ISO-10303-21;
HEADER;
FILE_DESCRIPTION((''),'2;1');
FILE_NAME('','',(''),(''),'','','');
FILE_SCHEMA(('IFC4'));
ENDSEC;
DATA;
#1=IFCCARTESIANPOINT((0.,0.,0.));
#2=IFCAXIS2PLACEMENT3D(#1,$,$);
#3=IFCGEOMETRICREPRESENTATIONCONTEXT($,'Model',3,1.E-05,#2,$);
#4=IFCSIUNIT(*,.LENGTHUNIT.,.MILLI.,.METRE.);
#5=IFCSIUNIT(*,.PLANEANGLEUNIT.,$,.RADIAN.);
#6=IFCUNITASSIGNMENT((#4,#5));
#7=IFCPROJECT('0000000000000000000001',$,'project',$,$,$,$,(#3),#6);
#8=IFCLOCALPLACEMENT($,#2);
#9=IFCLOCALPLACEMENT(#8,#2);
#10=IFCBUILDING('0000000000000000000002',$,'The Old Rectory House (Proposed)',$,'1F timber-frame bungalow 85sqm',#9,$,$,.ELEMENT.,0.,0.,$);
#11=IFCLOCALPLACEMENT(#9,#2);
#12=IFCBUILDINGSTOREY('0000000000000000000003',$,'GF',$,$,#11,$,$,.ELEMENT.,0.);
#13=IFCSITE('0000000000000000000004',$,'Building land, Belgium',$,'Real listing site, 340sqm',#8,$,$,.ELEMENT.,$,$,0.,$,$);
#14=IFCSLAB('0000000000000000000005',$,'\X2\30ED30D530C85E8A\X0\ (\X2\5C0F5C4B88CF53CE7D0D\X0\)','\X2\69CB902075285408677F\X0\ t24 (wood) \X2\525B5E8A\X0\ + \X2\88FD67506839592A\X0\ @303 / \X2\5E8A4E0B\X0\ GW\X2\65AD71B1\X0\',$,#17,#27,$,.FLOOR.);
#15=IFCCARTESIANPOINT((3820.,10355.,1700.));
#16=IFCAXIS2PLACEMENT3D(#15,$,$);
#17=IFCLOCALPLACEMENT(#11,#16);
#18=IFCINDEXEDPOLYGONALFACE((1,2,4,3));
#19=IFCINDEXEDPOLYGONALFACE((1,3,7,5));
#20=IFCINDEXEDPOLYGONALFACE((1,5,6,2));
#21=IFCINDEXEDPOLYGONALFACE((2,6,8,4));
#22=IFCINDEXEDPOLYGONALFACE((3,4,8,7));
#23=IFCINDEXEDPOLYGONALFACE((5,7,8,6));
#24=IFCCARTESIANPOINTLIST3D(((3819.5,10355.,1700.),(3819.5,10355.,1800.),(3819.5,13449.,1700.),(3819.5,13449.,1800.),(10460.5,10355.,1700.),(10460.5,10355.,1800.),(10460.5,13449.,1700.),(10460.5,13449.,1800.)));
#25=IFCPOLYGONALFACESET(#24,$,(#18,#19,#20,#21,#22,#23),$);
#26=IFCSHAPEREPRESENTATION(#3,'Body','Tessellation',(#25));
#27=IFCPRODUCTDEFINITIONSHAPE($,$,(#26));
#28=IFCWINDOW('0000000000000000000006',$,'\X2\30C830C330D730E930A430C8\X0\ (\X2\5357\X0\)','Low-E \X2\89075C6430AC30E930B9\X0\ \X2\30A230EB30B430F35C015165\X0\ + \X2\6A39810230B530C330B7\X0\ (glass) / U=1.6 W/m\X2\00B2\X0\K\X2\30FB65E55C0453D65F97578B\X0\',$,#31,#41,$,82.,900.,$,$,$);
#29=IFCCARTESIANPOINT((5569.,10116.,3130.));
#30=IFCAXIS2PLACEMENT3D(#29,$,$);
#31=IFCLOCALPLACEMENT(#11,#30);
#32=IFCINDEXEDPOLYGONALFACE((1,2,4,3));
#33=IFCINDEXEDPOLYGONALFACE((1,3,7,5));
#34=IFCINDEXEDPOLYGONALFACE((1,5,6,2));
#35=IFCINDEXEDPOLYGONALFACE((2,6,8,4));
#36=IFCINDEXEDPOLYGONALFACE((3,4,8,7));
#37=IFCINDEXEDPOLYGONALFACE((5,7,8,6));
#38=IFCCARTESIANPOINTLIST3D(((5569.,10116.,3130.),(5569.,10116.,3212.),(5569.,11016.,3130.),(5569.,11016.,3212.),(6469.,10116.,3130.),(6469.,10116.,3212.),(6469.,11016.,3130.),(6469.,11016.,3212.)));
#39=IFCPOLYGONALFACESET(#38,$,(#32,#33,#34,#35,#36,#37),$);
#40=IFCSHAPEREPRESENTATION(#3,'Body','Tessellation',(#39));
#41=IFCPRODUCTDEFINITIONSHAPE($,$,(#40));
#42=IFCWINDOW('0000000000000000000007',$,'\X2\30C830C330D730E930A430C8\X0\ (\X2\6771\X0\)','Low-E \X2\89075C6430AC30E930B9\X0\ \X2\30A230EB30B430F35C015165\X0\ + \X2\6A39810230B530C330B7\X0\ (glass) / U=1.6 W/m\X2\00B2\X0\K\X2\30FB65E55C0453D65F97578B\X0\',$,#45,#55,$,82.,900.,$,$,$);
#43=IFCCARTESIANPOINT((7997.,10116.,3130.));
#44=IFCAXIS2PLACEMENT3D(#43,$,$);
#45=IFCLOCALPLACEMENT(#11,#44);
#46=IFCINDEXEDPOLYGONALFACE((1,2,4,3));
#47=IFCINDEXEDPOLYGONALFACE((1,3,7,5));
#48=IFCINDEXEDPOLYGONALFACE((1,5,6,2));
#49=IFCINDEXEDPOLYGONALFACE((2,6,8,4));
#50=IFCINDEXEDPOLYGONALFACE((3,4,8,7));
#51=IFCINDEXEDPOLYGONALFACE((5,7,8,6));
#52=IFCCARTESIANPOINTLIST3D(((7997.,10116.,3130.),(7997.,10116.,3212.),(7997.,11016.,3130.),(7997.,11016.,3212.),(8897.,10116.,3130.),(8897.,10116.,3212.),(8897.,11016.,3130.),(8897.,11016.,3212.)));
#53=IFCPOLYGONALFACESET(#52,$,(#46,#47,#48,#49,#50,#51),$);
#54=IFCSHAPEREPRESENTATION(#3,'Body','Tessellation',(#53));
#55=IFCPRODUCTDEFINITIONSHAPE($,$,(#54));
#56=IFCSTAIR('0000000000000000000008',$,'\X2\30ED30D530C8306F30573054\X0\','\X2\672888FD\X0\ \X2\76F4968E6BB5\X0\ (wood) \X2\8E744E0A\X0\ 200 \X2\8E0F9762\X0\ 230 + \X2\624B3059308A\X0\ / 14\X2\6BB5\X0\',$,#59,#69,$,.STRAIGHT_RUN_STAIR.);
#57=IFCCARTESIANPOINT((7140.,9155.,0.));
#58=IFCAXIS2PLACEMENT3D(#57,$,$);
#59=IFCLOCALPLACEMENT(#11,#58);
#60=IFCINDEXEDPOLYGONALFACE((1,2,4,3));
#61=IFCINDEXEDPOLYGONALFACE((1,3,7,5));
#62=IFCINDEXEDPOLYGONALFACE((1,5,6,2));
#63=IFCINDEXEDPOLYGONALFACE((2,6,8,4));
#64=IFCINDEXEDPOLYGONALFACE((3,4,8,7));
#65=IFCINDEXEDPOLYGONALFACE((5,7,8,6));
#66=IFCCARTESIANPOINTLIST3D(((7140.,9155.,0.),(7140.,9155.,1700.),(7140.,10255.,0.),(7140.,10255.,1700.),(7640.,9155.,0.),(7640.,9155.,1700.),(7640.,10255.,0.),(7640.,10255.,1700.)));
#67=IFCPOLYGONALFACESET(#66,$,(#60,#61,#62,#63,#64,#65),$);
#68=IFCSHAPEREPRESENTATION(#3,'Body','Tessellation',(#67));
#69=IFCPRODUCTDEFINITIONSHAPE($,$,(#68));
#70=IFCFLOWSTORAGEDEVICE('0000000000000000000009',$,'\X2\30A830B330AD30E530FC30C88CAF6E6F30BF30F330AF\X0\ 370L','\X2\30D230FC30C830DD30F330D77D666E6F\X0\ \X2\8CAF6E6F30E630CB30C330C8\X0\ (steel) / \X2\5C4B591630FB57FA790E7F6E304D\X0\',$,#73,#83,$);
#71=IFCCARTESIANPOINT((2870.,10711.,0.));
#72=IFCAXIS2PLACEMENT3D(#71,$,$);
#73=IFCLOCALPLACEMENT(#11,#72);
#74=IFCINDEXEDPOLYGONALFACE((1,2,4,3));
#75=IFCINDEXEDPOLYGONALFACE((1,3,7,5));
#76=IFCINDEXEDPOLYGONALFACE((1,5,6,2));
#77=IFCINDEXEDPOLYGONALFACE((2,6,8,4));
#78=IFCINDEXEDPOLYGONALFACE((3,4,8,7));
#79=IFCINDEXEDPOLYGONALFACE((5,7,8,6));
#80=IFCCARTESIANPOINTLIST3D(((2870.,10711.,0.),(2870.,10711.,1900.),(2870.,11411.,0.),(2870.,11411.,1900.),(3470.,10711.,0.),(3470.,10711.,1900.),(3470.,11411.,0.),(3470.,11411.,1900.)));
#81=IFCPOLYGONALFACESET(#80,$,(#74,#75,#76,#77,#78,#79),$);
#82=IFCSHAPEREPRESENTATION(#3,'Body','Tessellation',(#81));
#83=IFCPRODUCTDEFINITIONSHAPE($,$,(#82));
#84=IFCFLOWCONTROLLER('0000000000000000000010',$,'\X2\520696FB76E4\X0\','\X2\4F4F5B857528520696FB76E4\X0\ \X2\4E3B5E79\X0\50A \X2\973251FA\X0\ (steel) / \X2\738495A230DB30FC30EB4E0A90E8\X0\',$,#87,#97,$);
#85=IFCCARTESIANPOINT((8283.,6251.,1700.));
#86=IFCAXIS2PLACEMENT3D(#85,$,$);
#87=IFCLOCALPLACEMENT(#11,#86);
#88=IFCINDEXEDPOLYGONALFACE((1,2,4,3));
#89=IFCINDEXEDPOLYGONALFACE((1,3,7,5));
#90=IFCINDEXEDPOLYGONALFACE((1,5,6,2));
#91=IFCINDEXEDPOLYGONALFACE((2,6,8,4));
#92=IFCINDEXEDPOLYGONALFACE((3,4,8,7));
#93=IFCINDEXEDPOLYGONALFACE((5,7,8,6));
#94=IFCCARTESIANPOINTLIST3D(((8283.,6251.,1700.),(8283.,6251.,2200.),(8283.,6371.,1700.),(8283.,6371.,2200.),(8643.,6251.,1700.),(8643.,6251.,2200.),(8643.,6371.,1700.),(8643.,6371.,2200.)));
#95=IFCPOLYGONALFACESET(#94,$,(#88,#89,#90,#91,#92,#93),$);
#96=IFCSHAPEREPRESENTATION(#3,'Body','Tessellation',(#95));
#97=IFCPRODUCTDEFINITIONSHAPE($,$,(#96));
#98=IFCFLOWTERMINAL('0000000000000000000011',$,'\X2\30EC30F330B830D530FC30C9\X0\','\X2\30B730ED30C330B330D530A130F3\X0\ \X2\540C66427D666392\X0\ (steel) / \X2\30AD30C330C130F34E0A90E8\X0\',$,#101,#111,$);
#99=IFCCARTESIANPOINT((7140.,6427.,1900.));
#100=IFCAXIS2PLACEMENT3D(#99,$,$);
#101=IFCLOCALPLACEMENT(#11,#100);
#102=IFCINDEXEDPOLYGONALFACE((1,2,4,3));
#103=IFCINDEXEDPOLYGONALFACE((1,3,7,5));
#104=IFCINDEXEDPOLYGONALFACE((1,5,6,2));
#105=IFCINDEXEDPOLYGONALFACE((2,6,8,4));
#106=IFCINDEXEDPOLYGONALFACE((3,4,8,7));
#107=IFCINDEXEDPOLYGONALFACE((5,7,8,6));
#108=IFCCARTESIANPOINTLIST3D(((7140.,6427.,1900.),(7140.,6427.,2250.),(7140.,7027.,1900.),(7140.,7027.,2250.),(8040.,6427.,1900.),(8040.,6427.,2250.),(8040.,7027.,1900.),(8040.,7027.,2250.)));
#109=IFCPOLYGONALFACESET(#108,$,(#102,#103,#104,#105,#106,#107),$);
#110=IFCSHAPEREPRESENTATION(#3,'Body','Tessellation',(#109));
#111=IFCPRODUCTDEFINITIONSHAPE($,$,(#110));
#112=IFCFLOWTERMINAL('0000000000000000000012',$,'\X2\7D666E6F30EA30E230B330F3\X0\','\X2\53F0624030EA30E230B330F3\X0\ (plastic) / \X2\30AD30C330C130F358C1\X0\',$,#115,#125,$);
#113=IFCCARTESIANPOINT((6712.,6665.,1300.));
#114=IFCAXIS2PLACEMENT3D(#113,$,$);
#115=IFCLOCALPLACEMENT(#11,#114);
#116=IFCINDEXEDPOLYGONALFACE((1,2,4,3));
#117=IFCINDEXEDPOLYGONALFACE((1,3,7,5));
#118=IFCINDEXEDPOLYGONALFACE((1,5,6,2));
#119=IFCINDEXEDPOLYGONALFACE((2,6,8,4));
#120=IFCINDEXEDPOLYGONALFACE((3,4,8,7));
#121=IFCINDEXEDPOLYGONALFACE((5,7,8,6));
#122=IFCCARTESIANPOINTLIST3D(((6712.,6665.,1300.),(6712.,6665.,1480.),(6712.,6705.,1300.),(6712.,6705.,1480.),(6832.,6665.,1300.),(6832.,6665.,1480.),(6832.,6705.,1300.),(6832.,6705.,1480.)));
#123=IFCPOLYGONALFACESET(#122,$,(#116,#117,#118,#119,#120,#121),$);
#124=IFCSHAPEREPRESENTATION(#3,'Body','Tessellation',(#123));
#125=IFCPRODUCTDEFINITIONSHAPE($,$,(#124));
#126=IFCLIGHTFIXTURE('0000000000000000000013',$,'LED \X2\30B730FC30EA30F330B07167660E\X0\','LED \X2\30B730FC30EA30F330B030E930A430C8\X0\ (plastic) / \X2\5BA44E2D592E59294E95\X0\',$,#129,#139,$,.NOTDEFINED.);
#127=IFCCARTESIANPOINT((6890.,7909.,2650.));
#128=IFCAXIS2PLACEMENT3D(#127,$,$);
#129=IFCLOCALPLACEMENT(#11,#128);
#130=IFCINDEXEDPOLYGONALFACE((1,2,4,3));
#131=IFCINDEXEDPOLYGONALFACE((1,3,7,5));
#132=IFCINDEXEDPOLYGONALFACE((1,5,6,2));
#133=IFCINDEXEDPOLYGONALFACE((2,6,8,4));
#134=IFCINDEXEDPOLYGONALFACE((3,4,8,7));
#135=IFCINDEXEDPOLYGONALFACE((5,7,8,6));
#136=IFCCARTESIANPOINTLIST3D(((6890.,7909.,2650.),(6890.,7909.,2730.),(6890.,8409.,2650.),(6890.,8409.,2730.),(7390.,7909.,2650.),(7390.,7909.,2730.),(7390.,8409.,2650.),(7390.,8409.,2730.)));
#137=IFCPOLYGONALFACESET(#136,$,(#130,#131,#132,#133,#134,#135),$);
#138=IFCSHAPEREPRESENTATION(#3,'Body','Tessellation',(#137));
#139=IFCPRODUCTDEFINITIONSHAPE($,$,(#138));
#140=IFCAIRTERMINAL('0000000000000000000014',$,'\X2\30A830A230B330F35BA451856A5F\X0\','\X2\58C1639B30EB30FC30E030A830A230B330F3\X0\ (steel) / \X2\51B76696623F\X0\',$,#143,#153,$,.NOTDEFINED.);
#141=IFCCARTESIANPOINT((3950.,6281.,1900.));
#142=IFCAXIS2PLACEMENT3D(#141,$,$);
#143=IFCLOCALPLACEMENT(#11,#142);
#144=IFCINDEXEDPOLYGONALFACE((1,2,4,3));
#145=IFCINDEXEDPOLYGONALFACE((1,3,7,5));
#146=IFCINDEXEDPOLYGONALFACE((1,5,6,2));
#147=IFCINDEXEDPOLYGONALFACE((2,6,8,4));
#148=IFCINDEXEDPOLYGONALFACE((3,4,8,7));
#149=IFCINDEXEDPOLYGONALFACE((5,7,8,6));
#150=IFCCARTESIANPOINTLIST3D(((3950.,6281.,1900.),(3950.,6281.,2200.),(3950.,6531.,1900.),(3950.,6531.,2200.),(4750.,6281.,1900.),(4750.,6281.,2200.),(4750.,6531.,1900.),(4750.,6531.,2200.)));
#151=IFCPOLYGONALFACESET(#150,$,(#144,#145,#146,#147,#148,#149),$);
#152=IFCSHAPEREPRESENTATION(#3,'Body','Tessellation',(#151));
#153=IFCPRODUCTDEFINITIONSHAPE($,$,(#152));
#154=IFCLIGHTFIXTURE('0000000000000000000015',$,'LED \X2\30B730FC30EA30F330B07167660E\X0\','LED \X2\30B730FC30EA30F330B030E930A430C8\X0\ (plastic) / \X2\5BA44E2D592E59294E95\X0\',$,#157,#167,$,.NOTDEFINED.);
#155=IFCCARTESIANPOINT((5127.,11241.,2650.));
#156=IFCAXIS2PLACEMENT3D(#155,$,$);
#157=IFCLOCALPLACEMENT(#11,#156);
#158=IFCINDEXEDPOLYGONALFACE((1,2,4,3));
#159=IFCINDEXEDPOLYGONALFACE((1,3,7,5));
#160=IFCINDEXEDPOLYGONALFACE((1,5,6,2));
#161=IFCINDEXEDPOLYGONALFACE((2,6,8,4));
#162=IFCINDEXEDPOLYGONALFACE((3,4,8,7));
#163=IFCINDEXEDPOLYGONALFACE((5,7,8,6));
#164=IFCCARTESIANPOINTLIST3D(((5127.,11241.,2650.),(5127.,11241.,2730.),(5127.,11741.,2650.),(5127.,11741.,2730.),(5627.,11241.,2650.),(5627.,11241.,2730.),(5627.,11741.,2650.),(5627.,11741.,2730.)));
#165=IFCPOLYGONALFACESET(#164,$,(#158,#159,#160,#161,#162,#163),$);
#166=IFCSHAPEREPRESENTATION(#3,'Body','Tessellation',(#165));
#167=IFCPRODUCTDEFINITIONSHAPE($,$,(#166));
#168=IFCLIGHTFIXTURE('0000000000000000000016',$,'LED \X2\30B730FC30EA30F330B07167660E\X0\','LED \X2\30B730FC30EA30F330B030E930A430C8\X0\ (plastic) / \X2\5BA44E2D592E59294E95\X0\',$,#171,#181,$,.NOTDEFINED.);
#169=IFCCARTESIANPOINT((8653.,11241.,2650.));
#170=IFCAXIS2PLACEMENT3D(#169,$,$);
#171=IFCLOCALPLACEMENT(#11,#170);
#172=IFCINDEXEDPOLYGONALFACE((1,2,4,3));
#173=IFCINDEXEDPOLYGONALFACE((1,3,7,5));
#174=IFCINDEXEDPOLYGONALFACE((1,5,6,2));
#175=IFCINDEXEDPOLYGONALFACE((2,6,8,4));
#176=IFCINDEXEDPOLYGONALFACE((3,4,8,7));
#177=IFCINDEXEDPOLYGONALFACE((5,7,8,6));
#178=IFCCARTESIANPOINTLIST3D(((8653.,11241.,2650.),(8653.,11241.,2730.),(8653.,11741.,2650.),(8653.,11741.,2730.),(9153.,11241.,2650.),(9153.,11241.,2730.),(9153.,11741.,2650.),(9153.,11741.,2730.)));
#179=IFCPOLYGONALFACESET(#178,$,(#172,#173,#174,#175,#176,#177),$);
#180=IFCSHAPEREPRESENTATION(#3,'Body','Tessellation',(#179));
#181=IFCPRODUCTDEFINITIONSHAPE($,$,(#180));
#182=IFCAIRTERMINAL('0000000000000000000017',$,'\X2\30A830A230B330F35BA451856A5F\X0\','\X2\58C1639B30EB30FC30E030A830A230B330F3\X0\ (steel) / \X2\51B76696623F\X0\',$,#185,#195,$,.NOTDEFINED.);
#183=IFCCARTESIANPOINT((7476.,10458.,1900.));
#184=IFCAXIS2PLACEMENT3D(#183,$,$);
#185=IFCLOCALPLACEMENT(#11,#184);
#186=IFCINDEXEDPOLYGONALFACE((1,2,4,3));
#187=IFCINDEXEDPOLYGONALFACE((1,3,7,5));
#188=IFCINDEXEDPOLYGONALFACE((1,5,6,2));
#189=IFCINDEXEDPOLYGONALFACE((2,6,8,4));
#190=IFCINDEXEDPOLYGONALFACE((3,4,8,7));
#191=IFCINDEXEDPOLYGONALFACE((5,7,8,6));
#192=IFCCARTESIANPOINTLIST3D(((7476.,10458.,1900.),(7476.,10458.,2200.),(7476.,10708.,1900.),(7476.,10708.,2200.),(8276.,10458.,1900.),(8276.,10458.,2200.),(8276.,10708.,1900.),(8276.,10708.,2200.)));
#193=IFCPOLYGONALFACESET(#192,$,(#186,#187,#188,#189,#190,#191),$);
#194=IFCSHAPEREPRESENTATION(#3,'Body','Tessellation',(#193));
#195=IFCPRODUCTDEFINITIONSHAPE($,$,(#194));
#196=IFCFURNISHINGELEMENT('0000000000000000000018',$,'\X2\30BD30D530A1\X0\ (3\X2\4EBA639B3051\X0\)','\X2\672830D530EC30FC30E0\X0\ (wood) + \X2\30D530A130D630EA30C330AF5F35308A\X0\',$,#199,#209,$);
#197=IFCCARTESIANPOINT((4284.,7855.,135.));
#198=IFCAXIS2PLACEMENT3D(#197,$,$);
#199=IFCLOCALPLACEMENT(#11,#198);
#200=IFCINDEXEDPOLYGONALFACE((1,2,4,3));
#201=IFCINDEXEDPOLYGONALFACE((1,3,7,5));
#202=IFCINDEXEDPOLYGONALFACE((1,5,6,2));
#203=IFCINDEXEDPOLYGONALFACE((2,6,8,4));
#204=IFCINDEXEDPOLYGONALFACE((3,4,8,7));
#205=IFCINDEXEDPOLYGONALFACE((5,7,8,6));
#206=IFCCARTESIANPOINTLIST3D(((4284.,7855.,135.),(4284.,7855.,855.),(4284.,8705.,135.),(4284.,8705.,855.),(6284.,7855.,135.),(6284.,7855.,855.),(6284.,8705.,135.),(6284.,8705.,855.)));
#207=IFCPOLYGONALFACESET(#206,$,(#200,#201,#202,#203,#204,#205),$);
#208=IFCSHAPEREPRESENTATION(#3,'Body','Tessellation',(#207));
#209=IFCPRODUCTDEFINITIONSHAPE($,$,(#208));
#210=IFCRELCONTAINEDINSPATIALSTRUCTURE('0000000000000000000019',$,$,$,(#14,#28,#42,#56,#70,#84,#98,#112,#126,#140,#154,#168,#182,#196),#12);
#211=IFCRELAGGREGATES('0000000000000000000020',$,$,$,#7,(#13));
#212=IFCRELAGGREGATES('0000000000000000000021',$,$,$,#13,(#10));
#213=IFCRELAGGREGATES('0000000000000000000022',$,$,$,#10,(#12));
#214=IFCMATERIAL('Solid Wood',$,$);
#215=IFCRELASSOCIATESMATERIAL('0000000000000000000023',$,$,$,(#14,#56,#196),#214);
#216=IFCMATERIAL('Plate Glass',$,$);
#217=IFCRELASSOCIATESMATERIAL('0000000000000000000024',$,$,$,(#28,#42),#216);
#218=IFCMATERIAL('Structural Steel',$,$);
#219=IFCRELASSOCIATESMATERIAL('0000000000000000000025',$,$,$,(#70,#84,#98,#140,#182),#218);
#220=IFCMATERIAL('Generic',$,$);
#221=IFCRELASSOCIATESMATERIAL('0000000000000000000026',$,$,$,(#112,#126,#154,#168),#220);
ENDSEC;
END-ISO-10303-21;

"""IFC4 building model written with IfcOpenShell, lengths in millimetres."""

from ifc_helpers import new_model, si_unit, frame, frame_2d, origin, place, context, project, spatial, rectangle, extrude, material, element, save


model = new_model("IFC4")

# Units and contexts
model_context = context("Model", 3, precision=1e-05, world=origin())
ifc_project = project(units=[si_unit("LENGTHUNIT", "METRE", prefix="MILLI"), si_unit("PLANEANGLEUNIT", "RADIAN")], contexts=[model_context])

# Site, building, storey
site_placement = place(None, origin())
site = spatial("IfcSite", under=ifc_project, at=site_placement, Name="Building land, Belgium", ObjectType="Real listing site, 340sqm", CompositionType="ELEMENT", RefElevation=0.0)
building_placement = place(site_placement, origin())
building = spatial("IfcBuilding", under=site, at=building_placement, Name="The Old Rectory House (Proposed)", ObjectType="1F timber-frame bungalow 85sqm", CompositionType="ELEMENT", ElevationOfRefHeight=0.0, ElevationOfTerrain=0.0)
storey_placement = place(building_placement, origin())
storey = spatial("IfcBuildingStorey", under=building, at=storey_placement, Name="GF", CompositionType="ELEMENT", Elevation=0.0)

# Shared definitions
ifc_material_1 = material(Name="Solid Wood")

# Slab
slab_placement = place(storey_placement, frame((3820.0, 10355.0, 1700.0)))
element("IfcSlab", 1, at=slab_placement, inside=storey, material=ifc_material_1, Name="ロフト床 (小屋裏収納)", Description="構造用合板 t24 (wood) 剛床 + 製材根太 @303 / 床下 GW断熱", PredefinedType="FLOOR", context=model_context, shape_type="SweptSolid", body=[
    extrude(rectangle(XDim=6641.0, YDim=3094.0, at=frame_2d((3320.0, 1547.0))), frame((3820.0, 10355.0, 1700.0)), (0.0, 0.0, 1.0), 100.0),
])

# Windows
ifc_material_2 = material(Name="Plate Glass")
window_1_placement = place(storey_placement, frame((5569.0, 10116.0, 3130.0)))
element("IfcWindow", 2, at=window_1_placement, inside=storey, material=ifc_material_2, Name="トップライト (南)", Description="Low-E 複層ガラス アルゴン封入 + 樹脂サッシ (glass) / U=1.6 W/m²K・日射取得型", OverallHeight=82.0, OverallWidth=900.0, context=model_context, shape_type="SweptSolid", body=[
    extrude(rectangle(XDim=900.0, YDim=900.0, at=frame_2d((450.0, 450.0))), frame((5569.0, 10116.0, 3130.0)), (0.0, 0.0, 1.0), 82.0),
])
window_2_placement = place(storey_placement, frame((7997.0, 10116.0, 3130.0)))
element("IfcWindow", 3, at=window_2_placement, inside=storey, material=ifc_material_2, Name="トップライト (東)", Description="Low-E 複層ガラス アルゴン封入 + 樹脂サッシ (glass) / U=1.6 W/m²K・日射取得型", OverallHeight=82.0, OverallWidth=900.0, context=model_context, shape_type="SweptSolid", body=[
    extrude(rectangle(XDim=900.0, YDim=900.0, at=frame_2d((450.0, 450.0))), frame((7997.0, 10116.0, 3130.0)), (0.0, 0.0, 1.0), 82.0),
])

# Stair
stair_placement = place(storey_placement, frame((7140.0, 9155.0, 0.0)))
element("IfcStair", 4, at=stair_placement, inside=storey, material=ifc_material_1, Name="ロフトはしご", Description="木製 直階段 (wood) 蹴上 200 踏面 230 + 手すり / 14段", PredefinedType="STRAIGHT_RUN_STAIR", context=model_context, shape_type="SweptSolid", body=[
    extrude(rectangle(XDim=500.0, YDim=1100.0, at=frame_2d((250.0, 550.0))), frame((7140.0, 9155.0, 0.0)), (0.0, 0.0, 1.0), 1700.0),
])

# Flow storage device
ifc_material_3 = material(Name="Structural Steel")
flow_storage_device_placement = place(storey_placement, frame((2870.0, 10711.0, 0.0)))
element("IfcFlowStorageDevice", 5, at=flow_storage_device_placement, inside=storey, material=ifc_material_3, Name="エコキュート貯湯タンク 370L", Description="ヒートポンプ給湯 貯湯ユニット (steel) / 屋外・基礎置き", context=model_context, shape_type="SweptSolid", body=[
    extrude(rectangle(XDim=600.0, YDim=700.0, at=frame_2d((300.0, 350.0))), frame((2870.0, 10711.0, 0.0)), (0.0, 0.0, 1.0), 1900.0),
])

# Flow controller
flow_controller_placement = place(storey_placement, frame((8283.0, 6251.0, 1700.0)))
element("IfcFlowController", 6, at=flow_controller_placement, inside=storey, material=ifc_material_3, Name="分電盤", Description="住宅用分電盤 主幹50A 露出 (steel) / 玄関ホール上部", context=model_context, shape_type="SweptSolid", body=[
    extrude(rectangle(XDim=360.0, YDim=120.0, at=frame_2d((180.0, 60.0))), frame((8283.0, 6251.0, 1700.0)), (0.0, 0.0, 1.0), 500.0),
])

# Flow terminals
flow_terminal_1_placement = place(storey_placement, frame((7140.0, 6427.0, 1900.0)))
element("IfcFlowTerminal", 7, at=flow_terminal_1_placement, inside=storey, material=ifc_material_3, Name="レンジフード", Description="シロッコファン 同時給排 (steel) / キッチン上部", context=model_context, shape_type="SweptSolid", body=[
    extrude(rectangle(XDim=900.0, YDim=600.0, at=frame_2d((450.0, 300.0))), frame((7140.0, 6427.0, 1900.0)), (0.0, 0.0, 1.0), 350.0),
])
ifc_material_4 = material(Name="Generic")
flow_terminal_2_placement = place(storey_placement, frame((6712.0, 6665.0, 1300.0)))
element("IfcFlowTerminal", 8, at=flow_terminal_2_placement, inside=storey, material=ifc_material_4, Name="給湯リモコン", Description="台所リモコン (plastic) / キッチン壁", context=model_context, shape_type="SweptSolid", body=[
    extrude(rectangle(XDim=120.0, YDim=40.0, at=frame_2d((60.0, 20.0))), frame((6712.0, 6665.0, 1300.0)), (0.0, 0.0, 1.0), 180.0),
])

# Light fixture
light_fixture_1_placement = place(storey_placement, frame((6890.0, 7909.0, 2650.0)))
element("IfcLightFixture", 9, at=light_fixture_1_placement, inside=storey, material=ifc_material_4, Name="LED シーリング照明", Description="LED シーリングライト (plastic) / 室中央天井", PredefinedType="NOTDEFINED", context=model_context, shape_type="SweptSolid", body=[
    extrude(rectangle(XDim=500.0, YDim=500.0, at=frame_2d((250.0, 250.0))), frame((6890.0, 7909.0, 2650.0)), (0.0, 0.0, 1.0), 80.0),
])

# Air terminal
air_terminal_1_placement = place(storey_placement, frame((3950.0, 6281.0, 1900.0)))
element("IfcAirTerminal", 10, at=air_terminal_1_placement, inside=storey, material=ifc_material_3, Name="エアコン室内機", Description="壁掛ルームエアコン (steel) / 冷暖房", PredefinedType="NOTDEFINED", context=model_context, shape_type="SweptSolid", body=[
    extrude(rectangle(XDim=800.0, YDim=250.0, at=frame_2d((400.0, 125.0))), frame((3950.0, 6281.0, 1900.0)), (0.0, 0.0, 1.0), 300.0),
])

# Light fixtures
light_fixture_2_placement = place(storey_placement, frame((5127.0, 11241.0, 2650.0)))
element("IfcLightFixture", 11, at=light_fixture_2_placement, inside=storey, material=ifc_material_4, Name="LED シーリング照明", Description="LED シーリングライト (plastic) / 室中央天井", PredefinedType="NOTDEFINED", context=model_context, shape_type="SweptSolid", body=[
    extrude(rectangle(XDim=500.0, YDim=500.0, at=frame_2d((250.0, 250.0))), frame((5127.0, 11241.0, 2650.0)), (0.0, 0.0, 1.0), 80.0),
])
light_fixture_3_placement = place(storey_placement, frame((8653.0, 11241.0, 2650.0)))
element("IfcLightFixture", 12, at=light_fixture_3_placement, inside=storey, material=ifc_material_4, Name="LED シーリング照明", Description="LED シーリングライト (plastic) / 室中央天井", PredefinedType="NOTDEFINED", context=model_context, shape_type="SweptSolid", body=[
    extrude(rectangle(XDim=500.0, YDim=500.0, at=frame_2d((250.0, 250.0))), frame((8653.0, 11241.0, 2650.0)), (0.0, 0.0, 1.0), 80.0),
])

# Air terminal
air_terminal_2_placement = place(storey_placement, frame((7476.0, 10458.0, 1900.0)))
element("IfcAirTerminal", 13, at=air_terminal_2_placement, inside=storey, material=ifc_material_3, Name="エアコン室内機", Description="壁掛ルームエアコン (steel) / 冷暖房", PredefinedType="NOTDEFINED", context=model_context, shape_type="SweptSolid", body=[
    extrude(rectangle(XDim=800.0, YDim=250.0, at=frame_2d((400.0, 125.0))), frame((7476.0, 10458.0, 1900.0)), (0.0, 0.0, 1.0), 300.0),
])

# Furnishing element
furnishing_1_placement = place(storey_placement, frame((4284.0, 7855.0, 135.0)))
element("IfcFurnishingElement", 14, at=furnishing_1_placement, inside=storey, material=ifc_material_1, Name="ソファ (3人掛け)", Description="木フレーム (wood) + ファブリック張り", context=model_context, shape_type="SweptSolid", body=[
    extrude(rectangle(XDim=2000.0, YDim=850.0, at=frame_2d((1000.0, 425.0))), frame((4284.0, 7855.0, 135.0)), (0.0, 0.0, 1.0), 720.0),
])

save(model, "model.ifc")
